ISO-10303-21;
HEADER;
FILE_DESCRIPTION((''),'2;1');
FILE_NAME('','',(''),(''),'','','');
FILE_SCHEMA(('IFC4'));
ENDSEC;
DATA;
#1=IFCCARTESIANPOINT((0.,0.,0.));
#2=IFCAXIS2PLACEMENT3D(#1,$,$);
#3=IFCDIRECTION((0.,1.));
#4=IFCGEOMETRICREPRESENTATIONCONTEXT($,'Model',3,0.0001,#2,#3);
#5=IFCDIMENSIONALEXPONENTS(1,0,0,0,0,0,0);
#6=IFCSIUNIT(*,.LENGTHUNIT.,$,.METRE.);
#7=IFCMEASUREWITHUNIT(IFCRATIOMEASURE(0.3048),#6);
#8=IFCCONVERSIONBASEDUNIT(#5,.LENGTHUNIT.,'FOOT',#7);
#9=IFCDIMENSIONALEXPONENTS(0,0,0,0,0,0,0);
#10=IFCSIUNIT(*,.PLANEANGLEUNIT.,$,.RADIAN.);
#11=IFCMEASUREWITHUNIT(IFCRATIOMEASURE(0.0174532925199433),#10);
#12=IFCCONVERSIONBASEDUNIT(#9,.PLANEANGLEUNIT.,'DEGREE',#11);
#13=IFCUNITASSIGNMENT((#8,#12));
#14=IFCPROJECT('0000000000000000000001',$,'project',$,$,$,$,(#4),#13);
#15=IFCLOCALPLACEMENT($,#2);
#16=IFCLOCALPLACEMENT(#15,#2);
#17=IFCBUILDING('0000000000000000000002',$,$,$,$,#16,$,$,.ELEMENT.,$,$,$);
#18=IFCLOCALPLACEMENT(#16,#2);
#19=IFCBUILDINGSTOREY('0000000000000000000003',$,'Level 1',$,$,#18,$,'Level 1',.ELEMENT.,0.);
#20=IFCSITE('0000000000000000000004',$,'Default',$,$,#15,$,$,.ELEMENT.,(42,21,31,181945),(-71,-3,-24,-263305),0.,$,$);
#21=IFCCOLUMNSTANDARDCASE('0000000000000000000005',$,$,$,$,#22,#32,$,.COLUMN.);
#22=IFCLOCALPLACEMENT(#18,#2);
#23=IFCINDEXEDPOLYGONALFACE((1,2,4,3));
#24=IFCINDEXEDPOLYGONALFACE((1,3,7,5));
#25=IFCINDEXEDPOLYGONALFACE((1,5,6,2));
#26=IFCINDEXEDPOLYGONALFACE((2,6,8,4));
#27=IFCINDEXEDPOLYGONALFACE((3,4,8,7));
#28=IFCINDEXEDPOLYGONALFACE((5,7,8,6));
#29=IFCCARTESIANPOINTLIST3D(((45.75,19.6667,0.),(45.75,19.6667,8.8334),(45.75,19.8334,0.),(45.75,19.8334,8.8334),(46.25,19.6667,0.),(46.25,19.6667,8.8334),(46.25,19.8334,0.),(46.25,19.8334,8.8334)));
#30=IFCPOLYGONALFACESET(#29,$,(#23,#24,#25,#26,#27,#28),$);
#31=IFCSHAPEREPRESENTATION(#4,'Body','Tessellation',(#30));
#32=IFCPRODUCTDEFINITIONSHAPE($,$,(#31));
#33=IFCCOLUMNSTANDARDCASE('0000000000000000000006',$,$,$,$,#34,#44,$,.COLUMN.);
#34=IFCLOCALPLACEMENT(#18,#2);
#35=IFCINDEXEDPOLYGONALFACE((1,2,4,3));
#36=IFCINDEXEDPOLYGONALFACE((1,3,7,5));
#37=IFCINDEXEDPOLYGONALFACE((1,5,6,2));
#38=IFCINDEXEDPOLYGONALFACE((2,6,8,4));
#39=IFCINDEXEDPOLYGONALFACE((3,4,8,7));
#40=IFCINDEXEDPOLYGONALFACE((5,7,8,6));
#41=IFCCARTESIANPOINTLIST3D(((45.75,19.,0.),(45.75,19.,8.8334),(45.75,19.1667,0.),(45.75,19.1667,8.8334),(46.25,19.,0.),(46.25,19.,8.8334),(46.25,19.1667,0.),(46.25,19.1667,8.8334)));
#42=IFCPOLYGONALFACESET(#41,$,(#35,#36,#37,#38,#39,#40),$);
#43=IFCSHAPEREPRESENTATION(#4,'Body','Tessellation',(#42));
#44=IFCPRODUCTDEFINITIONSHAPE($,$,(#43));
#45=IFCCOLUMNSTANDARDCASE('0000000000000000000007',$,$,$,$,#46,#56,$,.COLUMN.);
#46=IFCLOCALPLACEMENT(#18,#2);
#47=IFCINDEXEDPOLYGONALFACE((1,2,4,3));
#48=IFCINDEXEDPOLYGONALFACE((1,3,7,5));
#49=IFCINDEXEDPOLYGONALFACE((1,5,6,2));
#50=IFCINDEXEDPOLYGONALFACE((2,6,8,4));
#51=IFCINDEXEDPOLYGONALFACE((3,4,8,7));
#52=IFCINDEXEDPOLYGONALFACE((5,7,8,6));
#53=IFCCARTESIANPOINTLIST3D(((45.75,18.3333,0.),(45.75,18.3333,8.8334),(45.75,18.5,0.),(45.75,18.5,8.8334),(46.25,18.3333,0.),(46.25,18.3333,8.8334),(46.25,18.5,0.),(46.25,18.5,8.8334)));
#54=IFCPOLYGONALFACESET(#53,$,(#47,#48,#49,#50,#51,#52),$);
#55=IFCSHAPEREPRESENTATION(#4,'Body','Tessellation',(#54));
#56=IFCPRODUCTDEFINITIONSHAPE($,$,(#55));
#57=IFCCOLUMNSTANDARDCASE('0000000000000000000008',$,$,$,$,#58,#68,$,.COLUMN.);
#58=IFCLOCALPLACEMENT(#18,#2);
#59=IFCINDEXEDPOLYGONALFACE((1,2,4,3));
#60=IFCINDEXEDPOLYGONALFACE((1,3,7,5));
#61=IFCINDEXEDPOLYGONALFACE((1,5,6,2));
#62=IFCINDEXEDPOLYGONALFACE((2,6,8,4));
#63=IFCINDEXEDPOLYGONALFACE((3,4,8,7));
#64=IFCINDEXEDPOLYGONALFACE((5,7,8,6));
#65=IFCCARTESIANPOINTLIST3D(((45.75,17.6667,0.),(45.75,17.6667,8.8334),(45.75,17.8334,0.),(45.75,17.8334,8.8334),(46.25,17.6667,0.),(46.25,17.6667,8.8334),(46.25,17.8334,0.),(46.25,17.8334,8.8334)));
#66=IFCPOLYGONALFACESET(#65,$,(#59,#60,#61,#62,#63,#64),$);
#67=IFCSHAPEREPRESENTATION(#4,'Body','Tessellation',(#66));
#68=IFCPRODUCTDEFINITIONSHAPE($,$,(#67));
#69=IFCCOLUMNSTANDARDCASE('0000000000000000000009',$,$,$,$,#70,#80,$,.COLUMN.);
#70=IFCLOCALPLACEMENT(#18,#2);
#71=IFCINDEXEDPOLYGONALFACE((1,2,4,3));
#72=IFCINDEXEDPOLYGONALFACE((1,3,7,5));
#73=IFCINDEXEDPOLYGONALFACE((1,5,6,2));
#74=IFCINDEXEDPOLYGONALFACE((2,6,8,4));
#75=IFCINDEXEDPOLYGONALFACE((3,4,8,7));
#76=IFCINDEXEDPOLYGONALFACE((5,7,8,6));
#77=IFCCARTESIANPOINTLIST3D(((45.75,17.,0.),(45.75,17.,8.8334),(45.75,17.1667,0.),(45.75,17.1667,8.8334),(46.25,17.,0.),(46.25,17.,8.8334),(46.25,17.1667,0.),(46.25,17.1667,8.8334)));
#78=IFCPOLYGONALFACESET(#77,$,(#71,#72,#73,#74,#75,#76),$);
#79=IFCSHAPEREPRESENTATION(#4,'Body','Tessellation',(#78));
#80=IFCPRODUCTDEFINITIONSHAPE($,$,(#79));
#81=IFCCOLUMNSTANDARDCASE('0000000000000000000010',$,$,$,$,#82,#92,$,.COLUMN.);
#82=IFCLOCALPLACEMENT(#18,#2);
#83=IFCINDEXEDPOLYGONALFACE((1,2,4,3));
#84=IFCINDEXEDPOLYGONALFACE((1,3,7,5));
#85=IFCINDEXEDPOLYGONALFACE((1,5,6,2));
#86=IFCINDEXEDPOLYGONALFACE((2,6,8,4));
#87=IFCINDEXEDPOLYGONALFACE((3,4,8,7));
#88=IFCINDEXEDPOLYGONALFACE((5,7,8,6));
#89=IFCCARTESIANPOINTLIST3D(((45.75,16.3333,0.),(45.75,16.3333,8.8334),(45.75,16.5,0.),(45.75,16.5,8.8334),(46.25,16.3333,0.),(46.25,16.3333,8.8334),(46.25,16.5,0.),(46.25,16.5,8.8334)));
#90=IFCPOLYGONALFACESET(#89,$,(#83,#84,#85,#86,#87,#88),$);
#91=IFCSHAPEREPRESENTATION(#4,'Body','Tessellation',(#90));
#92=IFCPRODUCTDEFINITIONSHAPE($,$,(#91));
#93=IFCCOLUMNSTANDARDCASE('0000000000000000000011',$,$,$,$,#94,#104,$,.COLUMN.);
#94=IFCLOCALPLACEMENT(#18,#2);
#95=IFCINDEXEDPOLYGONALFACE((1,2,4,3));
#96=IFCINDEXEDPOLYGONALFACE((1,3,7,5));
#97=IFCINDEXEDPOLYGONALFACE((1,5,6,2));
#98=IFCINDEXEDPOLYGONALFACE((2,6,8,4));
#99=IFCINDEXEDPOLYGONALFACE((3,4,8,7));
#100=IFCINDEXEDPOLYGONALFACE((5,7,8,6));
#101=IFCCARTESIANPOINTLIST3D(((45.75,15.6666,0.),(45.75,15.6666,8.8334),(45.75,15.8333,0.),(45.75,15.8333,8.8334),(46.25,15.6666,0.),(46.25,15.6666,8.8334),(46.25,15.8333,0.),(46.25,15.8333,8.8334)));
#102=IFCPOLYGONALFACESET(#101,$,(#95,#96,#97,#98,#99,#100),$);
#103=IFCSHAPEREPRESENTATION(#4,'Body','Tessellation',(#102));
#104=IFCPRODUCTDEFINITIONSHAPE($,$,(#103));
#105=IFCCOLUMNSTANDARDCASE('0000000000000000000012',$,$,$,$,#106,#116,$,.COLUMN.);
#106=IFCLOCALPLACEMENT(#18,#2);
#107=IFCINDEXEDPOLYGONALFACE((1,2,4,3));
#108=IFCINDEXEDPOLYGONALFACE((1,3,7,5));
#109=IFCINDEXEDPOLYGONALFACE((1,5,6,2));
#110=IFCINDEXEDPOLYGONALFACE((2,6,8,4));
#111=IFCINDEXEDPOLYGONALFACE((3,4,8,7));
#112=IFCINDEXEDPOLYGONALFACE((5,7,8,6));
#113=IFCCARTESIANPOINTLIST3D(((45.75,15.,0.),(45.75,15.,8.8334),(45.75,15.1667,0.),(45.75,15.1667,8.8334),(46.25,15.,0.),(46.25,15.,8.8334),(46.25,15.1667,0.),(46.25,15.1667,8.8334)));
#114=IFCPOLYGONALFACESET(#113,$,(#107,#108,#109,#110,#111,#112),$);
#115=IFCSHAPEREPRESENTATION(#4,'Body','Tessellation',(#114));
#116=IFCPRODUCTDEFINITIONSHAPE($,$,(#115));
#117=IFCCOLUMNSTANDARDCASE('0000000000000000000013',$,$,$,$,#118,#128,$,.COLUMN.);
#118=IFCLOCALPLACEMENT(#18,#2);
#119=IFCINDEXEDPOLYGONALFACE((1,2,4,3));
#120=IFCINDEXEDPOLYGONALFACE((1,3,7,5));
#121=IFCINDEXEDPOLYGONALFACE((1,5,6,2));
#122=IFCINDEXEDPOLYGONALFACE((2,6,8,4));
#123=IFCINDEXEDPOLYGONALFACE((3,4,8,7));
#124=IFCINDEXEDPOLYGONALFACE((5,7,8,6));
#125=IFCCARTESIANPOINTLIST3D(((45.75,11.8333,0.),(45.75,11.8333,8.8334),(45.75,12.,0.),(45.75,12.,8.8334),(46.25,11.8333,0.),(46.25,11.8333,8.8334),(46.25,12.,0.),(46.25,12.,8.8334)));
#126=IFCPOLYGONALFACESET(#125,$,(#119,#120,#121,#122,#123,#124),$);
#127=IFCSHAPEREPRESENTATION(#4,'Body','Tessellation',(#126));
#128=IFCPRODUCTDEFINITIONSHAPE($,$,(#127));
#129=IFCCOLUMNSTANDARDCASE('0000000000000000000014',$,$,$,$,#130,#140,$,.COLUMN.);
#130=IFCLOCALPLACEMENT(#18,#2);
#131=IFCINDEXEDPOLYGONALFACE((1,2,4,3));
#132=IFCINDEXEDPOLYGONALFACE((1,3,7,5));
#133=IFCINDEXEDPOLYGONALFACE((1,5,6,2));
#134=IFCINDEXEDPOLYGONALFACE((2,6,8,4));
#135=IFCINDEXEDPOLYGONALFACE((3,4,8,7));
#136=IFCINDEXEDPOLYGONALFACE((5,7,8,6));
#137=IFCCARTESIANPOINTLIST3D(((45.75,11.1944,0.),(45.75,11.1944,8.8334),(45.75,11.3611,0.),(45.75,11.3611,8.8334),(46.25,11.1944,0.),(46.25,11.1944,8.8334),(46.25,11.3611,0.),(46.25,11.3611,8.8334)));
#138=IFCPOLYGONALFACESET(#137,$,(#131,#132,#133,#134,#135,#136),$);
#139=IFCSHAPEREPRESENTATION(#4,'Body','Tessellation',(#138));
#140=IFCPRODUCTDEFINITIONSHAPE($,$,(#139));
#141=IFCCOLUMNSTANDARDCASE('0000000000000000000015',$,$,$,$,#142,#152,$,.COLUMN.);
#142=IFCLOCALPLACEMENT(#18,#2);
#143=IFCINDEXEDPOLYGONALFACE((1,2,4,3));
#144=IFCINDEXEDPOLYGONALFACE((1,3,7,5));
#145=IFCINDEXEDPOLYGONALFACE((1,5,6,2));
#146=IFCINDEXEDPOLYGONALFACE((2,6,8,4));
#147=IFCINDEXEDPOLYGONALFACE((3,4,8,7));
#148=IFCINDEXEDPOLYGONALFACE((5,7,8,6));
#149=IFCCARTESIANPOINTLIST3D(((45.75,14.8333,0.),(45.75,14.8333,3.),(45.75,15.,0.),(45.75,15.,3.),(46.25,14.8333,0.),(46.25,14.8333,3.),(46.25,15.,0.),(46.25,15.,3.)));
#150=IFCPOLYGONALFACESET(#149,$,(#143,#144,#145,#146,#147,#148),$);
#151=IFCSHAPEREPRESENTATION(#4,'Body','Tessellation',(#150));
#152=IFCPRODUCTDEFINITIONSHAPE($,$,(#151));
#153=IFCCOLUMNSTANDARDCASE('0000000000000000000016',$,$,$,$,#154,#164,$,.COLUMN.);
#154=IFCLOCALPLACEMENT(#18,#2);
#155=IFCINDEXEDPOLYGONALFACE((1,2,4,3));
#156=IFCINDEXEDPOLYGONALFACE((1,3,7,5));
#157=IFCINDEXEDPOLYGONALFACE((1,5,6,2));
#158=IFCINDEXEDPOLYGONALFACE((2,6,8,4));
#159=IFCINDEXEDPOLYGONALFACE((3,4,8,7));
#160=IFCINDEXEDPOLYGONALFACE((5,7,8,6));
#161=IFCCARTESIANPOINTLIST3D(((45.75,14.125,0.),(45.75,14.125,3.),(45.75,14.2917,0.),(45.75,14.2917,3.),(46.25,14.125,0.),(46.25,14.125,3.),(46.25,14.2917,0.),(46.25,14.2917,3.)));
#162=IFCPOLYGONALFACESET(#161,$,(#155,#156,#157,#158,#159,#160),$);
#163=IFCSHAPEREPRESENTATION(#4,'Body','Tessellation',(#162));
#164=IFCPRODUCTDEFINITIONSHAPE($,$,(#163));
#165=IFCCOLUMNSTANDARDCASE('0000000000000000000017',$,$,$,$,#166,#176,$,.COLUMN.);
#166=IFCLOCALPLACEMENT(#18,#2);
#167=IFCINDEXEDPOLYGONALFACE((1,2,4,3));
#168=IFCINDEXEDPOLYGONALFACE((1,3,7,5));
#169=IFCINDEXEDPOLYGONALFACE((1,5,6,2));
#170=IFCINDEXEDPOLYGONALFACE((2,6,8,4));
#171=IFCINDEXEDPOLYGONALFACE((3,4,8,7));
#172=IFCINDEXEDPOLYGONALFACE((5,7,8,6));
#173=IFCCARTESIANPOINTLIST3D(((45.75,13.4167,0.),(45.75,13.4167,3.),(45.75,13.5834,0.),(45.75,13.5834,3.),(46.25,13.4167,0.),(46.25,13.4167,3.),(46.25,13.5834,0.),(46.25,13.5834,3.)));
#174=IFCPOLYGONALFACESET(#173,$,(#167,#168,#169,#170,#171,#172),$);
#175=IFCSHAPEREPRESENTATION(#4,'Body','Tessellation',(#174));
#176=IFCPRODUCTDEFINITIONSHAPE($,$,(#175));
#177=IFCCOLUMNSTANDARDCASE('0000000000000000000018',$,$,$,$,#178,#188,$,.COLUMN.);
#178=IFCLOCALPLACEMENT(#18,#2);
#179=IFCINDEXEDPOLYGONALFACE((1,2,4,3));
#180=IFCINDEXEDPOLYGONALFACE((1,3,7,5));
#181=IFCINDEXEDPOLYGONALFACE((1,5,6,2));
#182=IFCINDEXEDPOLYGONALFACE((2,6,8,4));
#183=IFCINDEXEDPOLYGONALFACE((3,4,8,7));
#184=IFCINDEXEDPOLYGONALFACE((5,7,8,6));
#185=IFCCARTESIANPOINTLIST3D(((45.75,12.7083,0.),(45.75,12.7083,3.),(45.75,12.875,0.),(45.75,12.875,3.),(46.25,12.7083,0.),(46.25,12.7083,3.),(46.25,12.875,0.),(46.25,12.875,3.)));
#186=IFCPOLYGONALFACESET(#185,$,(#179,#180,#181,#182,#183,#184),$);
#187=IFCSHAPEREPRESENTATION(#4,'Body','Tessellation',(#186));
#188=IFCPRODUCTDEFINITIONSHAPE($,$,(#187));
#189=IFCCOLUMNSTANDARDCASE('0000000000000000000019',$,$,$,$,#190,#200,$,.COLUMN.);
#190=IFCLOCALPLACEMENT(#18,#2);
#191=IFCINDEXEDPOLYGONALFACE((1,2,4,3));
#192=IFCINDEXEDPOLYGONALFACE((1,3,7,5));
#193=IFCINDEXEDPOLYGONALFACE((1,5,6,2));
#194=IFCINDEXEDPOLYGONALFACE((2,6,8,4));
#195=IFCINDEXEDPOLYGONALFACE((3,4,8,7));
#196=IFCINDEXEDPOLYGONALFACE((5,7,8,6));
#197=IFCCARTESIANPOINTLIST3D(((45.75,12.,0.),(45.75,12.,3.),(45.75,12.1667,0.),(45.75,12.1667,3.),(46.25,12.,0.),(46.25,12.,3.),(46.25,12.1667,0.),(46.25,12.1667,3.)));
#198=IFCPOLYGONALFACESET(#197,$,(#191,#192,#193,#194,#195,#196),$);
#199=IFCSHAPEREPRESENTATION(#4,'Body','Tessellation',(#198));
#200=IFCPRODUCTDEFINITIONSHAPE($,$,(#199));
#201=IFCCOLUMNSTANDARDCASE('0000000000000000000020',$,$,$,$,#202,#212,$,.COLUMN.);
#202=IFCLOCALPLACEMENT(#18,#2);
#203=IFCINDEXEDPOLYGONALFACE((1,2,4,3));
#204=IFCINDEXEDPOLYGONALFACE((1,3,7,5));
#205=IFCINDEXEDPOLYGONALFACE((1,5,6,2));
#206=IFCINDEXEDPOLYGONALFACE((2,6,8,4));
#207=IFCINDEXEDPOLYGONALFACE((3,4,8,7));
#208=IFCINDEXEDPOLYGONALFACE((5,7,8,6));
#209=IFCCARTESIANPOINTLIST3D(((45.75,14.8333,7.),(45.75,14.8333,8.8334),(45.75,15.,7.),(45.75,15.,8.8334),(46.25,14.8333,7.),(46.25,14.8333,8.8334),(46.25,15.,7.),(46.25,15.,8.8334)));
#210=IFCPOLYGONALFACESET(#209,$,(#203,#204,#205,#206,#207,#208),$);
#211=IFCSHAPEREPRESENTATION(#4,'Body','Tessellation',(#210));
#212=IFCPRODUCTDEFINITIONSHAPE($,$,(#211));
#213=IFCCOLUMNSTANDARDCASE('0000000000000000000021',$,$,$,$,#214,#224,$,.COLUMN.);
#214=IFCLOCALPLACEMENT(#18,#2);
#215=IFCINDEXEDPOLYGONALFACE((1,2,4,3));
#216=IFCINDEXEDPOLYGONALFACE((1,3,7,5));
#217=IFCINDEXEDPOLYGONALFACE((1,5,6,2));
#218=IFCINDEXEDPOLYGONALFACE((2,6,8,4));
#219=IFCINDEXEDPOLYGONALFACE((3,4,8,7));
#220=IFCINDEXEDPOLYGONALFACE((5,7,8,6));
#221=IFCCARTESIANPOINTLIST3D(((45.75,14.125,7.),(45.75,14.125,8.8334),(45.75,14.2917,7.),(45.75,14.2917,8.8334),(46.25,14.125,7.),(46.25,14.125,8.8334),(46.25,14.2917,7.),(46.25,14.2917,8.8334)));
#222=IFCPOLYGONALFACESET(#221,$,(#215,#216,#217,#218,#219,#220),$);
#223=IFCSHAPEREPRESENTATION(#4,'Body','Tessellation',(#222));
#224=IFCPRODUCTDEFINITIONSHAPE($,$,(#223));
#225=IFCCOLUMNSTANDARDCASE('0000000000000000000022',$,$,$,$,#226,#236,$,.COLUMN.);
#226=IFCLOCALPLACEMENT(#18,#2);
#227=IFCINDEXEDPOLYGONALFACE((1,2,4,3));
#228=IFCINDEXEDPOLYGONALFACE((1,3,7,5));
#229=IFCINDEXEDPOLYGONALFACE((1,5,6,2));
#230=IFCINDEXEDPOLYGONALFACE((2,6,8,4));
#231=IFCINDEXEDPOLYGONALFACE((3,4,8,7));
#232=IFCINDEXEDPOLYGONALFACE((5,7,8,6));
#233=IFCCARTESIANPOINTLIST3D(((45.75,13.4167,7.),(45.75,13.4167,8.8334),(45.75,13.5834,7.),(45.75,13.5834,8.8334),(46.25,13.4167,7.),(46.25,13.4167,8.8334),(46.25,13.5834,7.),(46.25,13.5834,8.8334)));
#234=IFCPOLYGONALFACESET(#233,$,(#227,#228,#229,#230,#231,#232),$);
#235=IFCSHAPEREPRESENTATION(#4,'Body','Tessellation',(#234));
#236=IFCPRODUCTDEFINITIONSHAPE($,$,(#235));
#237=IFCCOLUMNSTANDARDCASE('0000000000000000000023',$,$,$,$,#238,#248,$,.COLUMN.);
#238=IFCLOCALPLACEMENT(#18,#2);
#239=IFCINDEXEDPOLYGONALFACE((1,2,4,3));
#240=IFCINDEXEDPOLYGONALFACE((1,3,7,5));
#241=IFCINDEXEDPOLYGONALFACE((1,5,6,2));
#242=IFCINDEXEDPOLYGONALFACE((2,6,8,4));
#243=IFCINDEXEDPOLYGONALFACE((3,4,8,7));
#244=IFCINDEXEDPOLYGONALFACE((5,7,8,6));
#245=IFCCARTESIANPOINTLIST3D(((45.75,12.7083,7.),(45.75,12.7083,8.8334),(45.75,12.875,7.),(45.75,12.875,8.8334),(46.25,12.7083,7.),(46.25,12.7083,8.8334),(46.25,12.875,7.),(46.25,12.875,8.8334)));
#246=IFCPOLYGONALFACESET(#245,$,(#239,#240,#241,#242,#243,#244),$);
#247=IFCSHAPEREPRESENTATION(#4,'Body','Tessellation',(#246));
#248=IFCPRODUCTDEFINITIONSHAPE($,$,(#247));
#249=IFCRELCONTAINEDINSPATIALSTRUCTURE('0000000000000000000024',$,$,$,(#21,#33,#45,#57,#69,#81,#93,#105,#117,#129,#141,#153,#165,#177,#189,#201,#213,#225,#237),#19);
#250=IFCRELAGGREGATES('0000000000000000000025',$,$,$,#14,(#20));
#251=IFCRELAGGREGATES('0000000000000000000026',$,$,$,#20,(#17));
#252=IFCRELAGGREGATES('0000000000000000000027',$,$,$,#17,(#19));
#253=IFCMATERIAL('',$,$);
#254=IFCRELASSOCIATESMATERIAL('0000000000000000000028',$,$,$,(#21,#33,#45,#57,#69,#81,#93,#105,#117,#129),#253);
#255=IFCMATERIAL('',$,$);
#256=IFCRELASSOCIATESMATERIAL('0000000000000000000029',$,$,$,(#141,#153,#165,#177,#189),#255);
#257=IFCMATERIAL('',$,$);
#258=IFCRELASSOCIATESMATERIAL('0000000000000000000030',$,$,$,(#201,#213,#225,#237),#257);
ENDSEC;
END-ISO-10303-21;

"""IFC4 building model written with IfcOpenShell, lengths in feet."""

from ifc_helpers import new_model, entity, si_unit, converted_unit, direction, frame, origin, place, context, project, spatial, rectangle, extrude, material, element, save


model = new_model("IFC4")

# Units and contexts
model_context = context("Model", 3, precision=0.0001, world=origin(), true_north=direction((0.0, 1.0)))
ifc_project = project(units=[converted_unit("LENGTHUNIT", "FOOT", entity("IfcRatioMeasure", 0.3048), si_unit("LENGTHUNIT", "METRE"), dimensions=[1, 0, 0, 0, 0, 0, 0]), converted_unit("PLANEANGLEUNIT", "DEGREE", entity("IfcRatioMeasure", 0.0174532925199433), si_unit("PLANEANGLEUNIT", "RADIAN"), dimensions=[0, 0, 0, 0, 0, 0, 0])], contexts=[model_context])

# Site, building, storey
site_placement = place(None, origin())
site = spatial("IfcSite", under=ifc_project, at=site_placement, Name="Default", CompositionType="ELEMENT", RefLatitude=(42, 21, 31, 181945), RefLongitude=(-71, -3, -24, -263305), RefElevation=0.0)
building_placement = place(site_placement, origin())
building = spatial("IfcBuilding", under=site, at=building_placement, CompositionType="ELEMENT")
storey_placement = place(building_placement, origin())
storey = spatial("IfcBuildingStorey", under=building, at=storey_placement, Name="Level 1", LongName="Level 1", CompositionType="ELEMENT", Elevation=0.0)

# Columns
ifc_material_1 = material(Name="")
placement_1 = place(storey_placement, frame((46.0, 46.25, 0.0), z_axis=(0.0, 0.0, 1.0), x_axis=(0.0, -1.0, 0.0)))
for number, where, z_axis, x_axis in (
    (1, (26.5, 0.0, 0.0), (0.0, 0.0, 1.0), (1.0, 0.0, 0.0)),
    (2, (27.1667, 0.0, 0.0), (0.0, 0.0, 1.0), (1.0, 0.0, 0.0)),
    (3, (27.8334, 0.0, 0.0), (0.0, 0.0, 1.0), (1.0, 0.0, 0.0)),
    (4, (28.5, 0.0, 0.0), (0.0, 0.0, 1.0), (1.0, 0.0, 0.0)),
    (5, (29.1667, 0.0, 0.0), (0.0, 0.0, 1.0), (1.0, 0.0, 0.0)),
    (6, (29.8334, 0.0, 0.0), (0.0, 0.0, 1.0), (1.0, 0.0, 0.0)),
    (7, (30.5001, 0.0, 0.0), (0.0, 0.0, 1.0), (1.0, 0.0, 0.0)),
    (8, (31.1667, 0.0, 0.0), (0.0, 0.0, 1.0), (1.0, 0.0, 0.0)),
    (9, (34.3334, 0.0, 0.0), (0.0, 0.0, 1.0), (1.0, 0.0, 0.0)),
    (10, (34.9723, 0.0, 0.0), (0.0, 0.0, 1.0), (1.0, 0.0, 0.0)),
):
    element("IfcColumnStandardCase", number, at=place(placement_1, frame(where, z_axis=z_axis, x_axis=x_axis)), inside=storey, material=ifc_material_1, PredefinedType="COLUMN", context=model_context, shape_type="SweptSolid", body=[
        extrude(rectangle(XDim=0.1667, YDim=0.5), origin(), (0.0, 0.0, 1.0), 8.8334),
    ])
ifc_material_2 = material(Name="")
for number, where, z_axis, x_axis in (
    (11, (31.3334, 0.0, 0.0), (0.0, 0.0, 1.0), (1.0, 0.0, 0.0)),
    (12, (32.0417, 0.0, 0.0), (0.0, 0.0, 1.0), (1.0, 0.0, 0.0)),
    (13, (32.75, 0.0, 0.0), (0.0, 0.0, 1.0), (1.0, 0.0, 0.0)),
    (14, (33.4584, 0.0, 0.0), (0.0, 0.0, 1.0), (1.0, 0.0, 0.0)),
    (15, (34.1667, 0.0, 0.0), (0.0, 0.0, 1.0), (1.0, 0.0, 0.0)),
):
    element("IfcColumnStandardCase", number, at=place(placement_1, frame(where, z_axis=z_axis, x_axis=x_axis)), inside=storey, material=ifc_material_2, PredefinedType="COLUMN", context=model_context, shape_type="SweptSolid", body=[
        extrude(rectangle(XDim=0.1667, YDim=0.5), origin(), (0.0, 0.0, 1.0), 3.0),
    ])
ifc_material_3 = material(Name="")
for number, where, z_axis, x_axis in (
    (16, (31.3334, 0.0, 7.0), (0.0, 0.0, 1.0), (1.0, 0.0, 0.0)),
    (17, (32.0417, 0.0, 7.0), (0.0, 0.0, 1.0), (1.0, 0.0, 0.0)),
    (18, (32.75, 0.0, 7.0), (0.0, 0.0, 1.0), (1.0, 0.0, 0.0)),
    (19, (33.4584, 0.0, 7.0), (0.0, 0.0, 1.0), (1.0, 0.0, 0.0)),
):
    element("IfcColumnStandardCase", number, at=place(placement_1, frame(where, z_axis=z_axis, x_axis=x_axis)), inside=storey, material=ifc_material_3, PredefinedType="COLUMN", context=model_context, shape_type="SweptSolid", body=[
        extrude(rectangle(XDim=0.1667, YDim=0.5), origin(), (0.0, 0.0, 1.0), 1.8334),
    ])

save(model, "model.ifc")
